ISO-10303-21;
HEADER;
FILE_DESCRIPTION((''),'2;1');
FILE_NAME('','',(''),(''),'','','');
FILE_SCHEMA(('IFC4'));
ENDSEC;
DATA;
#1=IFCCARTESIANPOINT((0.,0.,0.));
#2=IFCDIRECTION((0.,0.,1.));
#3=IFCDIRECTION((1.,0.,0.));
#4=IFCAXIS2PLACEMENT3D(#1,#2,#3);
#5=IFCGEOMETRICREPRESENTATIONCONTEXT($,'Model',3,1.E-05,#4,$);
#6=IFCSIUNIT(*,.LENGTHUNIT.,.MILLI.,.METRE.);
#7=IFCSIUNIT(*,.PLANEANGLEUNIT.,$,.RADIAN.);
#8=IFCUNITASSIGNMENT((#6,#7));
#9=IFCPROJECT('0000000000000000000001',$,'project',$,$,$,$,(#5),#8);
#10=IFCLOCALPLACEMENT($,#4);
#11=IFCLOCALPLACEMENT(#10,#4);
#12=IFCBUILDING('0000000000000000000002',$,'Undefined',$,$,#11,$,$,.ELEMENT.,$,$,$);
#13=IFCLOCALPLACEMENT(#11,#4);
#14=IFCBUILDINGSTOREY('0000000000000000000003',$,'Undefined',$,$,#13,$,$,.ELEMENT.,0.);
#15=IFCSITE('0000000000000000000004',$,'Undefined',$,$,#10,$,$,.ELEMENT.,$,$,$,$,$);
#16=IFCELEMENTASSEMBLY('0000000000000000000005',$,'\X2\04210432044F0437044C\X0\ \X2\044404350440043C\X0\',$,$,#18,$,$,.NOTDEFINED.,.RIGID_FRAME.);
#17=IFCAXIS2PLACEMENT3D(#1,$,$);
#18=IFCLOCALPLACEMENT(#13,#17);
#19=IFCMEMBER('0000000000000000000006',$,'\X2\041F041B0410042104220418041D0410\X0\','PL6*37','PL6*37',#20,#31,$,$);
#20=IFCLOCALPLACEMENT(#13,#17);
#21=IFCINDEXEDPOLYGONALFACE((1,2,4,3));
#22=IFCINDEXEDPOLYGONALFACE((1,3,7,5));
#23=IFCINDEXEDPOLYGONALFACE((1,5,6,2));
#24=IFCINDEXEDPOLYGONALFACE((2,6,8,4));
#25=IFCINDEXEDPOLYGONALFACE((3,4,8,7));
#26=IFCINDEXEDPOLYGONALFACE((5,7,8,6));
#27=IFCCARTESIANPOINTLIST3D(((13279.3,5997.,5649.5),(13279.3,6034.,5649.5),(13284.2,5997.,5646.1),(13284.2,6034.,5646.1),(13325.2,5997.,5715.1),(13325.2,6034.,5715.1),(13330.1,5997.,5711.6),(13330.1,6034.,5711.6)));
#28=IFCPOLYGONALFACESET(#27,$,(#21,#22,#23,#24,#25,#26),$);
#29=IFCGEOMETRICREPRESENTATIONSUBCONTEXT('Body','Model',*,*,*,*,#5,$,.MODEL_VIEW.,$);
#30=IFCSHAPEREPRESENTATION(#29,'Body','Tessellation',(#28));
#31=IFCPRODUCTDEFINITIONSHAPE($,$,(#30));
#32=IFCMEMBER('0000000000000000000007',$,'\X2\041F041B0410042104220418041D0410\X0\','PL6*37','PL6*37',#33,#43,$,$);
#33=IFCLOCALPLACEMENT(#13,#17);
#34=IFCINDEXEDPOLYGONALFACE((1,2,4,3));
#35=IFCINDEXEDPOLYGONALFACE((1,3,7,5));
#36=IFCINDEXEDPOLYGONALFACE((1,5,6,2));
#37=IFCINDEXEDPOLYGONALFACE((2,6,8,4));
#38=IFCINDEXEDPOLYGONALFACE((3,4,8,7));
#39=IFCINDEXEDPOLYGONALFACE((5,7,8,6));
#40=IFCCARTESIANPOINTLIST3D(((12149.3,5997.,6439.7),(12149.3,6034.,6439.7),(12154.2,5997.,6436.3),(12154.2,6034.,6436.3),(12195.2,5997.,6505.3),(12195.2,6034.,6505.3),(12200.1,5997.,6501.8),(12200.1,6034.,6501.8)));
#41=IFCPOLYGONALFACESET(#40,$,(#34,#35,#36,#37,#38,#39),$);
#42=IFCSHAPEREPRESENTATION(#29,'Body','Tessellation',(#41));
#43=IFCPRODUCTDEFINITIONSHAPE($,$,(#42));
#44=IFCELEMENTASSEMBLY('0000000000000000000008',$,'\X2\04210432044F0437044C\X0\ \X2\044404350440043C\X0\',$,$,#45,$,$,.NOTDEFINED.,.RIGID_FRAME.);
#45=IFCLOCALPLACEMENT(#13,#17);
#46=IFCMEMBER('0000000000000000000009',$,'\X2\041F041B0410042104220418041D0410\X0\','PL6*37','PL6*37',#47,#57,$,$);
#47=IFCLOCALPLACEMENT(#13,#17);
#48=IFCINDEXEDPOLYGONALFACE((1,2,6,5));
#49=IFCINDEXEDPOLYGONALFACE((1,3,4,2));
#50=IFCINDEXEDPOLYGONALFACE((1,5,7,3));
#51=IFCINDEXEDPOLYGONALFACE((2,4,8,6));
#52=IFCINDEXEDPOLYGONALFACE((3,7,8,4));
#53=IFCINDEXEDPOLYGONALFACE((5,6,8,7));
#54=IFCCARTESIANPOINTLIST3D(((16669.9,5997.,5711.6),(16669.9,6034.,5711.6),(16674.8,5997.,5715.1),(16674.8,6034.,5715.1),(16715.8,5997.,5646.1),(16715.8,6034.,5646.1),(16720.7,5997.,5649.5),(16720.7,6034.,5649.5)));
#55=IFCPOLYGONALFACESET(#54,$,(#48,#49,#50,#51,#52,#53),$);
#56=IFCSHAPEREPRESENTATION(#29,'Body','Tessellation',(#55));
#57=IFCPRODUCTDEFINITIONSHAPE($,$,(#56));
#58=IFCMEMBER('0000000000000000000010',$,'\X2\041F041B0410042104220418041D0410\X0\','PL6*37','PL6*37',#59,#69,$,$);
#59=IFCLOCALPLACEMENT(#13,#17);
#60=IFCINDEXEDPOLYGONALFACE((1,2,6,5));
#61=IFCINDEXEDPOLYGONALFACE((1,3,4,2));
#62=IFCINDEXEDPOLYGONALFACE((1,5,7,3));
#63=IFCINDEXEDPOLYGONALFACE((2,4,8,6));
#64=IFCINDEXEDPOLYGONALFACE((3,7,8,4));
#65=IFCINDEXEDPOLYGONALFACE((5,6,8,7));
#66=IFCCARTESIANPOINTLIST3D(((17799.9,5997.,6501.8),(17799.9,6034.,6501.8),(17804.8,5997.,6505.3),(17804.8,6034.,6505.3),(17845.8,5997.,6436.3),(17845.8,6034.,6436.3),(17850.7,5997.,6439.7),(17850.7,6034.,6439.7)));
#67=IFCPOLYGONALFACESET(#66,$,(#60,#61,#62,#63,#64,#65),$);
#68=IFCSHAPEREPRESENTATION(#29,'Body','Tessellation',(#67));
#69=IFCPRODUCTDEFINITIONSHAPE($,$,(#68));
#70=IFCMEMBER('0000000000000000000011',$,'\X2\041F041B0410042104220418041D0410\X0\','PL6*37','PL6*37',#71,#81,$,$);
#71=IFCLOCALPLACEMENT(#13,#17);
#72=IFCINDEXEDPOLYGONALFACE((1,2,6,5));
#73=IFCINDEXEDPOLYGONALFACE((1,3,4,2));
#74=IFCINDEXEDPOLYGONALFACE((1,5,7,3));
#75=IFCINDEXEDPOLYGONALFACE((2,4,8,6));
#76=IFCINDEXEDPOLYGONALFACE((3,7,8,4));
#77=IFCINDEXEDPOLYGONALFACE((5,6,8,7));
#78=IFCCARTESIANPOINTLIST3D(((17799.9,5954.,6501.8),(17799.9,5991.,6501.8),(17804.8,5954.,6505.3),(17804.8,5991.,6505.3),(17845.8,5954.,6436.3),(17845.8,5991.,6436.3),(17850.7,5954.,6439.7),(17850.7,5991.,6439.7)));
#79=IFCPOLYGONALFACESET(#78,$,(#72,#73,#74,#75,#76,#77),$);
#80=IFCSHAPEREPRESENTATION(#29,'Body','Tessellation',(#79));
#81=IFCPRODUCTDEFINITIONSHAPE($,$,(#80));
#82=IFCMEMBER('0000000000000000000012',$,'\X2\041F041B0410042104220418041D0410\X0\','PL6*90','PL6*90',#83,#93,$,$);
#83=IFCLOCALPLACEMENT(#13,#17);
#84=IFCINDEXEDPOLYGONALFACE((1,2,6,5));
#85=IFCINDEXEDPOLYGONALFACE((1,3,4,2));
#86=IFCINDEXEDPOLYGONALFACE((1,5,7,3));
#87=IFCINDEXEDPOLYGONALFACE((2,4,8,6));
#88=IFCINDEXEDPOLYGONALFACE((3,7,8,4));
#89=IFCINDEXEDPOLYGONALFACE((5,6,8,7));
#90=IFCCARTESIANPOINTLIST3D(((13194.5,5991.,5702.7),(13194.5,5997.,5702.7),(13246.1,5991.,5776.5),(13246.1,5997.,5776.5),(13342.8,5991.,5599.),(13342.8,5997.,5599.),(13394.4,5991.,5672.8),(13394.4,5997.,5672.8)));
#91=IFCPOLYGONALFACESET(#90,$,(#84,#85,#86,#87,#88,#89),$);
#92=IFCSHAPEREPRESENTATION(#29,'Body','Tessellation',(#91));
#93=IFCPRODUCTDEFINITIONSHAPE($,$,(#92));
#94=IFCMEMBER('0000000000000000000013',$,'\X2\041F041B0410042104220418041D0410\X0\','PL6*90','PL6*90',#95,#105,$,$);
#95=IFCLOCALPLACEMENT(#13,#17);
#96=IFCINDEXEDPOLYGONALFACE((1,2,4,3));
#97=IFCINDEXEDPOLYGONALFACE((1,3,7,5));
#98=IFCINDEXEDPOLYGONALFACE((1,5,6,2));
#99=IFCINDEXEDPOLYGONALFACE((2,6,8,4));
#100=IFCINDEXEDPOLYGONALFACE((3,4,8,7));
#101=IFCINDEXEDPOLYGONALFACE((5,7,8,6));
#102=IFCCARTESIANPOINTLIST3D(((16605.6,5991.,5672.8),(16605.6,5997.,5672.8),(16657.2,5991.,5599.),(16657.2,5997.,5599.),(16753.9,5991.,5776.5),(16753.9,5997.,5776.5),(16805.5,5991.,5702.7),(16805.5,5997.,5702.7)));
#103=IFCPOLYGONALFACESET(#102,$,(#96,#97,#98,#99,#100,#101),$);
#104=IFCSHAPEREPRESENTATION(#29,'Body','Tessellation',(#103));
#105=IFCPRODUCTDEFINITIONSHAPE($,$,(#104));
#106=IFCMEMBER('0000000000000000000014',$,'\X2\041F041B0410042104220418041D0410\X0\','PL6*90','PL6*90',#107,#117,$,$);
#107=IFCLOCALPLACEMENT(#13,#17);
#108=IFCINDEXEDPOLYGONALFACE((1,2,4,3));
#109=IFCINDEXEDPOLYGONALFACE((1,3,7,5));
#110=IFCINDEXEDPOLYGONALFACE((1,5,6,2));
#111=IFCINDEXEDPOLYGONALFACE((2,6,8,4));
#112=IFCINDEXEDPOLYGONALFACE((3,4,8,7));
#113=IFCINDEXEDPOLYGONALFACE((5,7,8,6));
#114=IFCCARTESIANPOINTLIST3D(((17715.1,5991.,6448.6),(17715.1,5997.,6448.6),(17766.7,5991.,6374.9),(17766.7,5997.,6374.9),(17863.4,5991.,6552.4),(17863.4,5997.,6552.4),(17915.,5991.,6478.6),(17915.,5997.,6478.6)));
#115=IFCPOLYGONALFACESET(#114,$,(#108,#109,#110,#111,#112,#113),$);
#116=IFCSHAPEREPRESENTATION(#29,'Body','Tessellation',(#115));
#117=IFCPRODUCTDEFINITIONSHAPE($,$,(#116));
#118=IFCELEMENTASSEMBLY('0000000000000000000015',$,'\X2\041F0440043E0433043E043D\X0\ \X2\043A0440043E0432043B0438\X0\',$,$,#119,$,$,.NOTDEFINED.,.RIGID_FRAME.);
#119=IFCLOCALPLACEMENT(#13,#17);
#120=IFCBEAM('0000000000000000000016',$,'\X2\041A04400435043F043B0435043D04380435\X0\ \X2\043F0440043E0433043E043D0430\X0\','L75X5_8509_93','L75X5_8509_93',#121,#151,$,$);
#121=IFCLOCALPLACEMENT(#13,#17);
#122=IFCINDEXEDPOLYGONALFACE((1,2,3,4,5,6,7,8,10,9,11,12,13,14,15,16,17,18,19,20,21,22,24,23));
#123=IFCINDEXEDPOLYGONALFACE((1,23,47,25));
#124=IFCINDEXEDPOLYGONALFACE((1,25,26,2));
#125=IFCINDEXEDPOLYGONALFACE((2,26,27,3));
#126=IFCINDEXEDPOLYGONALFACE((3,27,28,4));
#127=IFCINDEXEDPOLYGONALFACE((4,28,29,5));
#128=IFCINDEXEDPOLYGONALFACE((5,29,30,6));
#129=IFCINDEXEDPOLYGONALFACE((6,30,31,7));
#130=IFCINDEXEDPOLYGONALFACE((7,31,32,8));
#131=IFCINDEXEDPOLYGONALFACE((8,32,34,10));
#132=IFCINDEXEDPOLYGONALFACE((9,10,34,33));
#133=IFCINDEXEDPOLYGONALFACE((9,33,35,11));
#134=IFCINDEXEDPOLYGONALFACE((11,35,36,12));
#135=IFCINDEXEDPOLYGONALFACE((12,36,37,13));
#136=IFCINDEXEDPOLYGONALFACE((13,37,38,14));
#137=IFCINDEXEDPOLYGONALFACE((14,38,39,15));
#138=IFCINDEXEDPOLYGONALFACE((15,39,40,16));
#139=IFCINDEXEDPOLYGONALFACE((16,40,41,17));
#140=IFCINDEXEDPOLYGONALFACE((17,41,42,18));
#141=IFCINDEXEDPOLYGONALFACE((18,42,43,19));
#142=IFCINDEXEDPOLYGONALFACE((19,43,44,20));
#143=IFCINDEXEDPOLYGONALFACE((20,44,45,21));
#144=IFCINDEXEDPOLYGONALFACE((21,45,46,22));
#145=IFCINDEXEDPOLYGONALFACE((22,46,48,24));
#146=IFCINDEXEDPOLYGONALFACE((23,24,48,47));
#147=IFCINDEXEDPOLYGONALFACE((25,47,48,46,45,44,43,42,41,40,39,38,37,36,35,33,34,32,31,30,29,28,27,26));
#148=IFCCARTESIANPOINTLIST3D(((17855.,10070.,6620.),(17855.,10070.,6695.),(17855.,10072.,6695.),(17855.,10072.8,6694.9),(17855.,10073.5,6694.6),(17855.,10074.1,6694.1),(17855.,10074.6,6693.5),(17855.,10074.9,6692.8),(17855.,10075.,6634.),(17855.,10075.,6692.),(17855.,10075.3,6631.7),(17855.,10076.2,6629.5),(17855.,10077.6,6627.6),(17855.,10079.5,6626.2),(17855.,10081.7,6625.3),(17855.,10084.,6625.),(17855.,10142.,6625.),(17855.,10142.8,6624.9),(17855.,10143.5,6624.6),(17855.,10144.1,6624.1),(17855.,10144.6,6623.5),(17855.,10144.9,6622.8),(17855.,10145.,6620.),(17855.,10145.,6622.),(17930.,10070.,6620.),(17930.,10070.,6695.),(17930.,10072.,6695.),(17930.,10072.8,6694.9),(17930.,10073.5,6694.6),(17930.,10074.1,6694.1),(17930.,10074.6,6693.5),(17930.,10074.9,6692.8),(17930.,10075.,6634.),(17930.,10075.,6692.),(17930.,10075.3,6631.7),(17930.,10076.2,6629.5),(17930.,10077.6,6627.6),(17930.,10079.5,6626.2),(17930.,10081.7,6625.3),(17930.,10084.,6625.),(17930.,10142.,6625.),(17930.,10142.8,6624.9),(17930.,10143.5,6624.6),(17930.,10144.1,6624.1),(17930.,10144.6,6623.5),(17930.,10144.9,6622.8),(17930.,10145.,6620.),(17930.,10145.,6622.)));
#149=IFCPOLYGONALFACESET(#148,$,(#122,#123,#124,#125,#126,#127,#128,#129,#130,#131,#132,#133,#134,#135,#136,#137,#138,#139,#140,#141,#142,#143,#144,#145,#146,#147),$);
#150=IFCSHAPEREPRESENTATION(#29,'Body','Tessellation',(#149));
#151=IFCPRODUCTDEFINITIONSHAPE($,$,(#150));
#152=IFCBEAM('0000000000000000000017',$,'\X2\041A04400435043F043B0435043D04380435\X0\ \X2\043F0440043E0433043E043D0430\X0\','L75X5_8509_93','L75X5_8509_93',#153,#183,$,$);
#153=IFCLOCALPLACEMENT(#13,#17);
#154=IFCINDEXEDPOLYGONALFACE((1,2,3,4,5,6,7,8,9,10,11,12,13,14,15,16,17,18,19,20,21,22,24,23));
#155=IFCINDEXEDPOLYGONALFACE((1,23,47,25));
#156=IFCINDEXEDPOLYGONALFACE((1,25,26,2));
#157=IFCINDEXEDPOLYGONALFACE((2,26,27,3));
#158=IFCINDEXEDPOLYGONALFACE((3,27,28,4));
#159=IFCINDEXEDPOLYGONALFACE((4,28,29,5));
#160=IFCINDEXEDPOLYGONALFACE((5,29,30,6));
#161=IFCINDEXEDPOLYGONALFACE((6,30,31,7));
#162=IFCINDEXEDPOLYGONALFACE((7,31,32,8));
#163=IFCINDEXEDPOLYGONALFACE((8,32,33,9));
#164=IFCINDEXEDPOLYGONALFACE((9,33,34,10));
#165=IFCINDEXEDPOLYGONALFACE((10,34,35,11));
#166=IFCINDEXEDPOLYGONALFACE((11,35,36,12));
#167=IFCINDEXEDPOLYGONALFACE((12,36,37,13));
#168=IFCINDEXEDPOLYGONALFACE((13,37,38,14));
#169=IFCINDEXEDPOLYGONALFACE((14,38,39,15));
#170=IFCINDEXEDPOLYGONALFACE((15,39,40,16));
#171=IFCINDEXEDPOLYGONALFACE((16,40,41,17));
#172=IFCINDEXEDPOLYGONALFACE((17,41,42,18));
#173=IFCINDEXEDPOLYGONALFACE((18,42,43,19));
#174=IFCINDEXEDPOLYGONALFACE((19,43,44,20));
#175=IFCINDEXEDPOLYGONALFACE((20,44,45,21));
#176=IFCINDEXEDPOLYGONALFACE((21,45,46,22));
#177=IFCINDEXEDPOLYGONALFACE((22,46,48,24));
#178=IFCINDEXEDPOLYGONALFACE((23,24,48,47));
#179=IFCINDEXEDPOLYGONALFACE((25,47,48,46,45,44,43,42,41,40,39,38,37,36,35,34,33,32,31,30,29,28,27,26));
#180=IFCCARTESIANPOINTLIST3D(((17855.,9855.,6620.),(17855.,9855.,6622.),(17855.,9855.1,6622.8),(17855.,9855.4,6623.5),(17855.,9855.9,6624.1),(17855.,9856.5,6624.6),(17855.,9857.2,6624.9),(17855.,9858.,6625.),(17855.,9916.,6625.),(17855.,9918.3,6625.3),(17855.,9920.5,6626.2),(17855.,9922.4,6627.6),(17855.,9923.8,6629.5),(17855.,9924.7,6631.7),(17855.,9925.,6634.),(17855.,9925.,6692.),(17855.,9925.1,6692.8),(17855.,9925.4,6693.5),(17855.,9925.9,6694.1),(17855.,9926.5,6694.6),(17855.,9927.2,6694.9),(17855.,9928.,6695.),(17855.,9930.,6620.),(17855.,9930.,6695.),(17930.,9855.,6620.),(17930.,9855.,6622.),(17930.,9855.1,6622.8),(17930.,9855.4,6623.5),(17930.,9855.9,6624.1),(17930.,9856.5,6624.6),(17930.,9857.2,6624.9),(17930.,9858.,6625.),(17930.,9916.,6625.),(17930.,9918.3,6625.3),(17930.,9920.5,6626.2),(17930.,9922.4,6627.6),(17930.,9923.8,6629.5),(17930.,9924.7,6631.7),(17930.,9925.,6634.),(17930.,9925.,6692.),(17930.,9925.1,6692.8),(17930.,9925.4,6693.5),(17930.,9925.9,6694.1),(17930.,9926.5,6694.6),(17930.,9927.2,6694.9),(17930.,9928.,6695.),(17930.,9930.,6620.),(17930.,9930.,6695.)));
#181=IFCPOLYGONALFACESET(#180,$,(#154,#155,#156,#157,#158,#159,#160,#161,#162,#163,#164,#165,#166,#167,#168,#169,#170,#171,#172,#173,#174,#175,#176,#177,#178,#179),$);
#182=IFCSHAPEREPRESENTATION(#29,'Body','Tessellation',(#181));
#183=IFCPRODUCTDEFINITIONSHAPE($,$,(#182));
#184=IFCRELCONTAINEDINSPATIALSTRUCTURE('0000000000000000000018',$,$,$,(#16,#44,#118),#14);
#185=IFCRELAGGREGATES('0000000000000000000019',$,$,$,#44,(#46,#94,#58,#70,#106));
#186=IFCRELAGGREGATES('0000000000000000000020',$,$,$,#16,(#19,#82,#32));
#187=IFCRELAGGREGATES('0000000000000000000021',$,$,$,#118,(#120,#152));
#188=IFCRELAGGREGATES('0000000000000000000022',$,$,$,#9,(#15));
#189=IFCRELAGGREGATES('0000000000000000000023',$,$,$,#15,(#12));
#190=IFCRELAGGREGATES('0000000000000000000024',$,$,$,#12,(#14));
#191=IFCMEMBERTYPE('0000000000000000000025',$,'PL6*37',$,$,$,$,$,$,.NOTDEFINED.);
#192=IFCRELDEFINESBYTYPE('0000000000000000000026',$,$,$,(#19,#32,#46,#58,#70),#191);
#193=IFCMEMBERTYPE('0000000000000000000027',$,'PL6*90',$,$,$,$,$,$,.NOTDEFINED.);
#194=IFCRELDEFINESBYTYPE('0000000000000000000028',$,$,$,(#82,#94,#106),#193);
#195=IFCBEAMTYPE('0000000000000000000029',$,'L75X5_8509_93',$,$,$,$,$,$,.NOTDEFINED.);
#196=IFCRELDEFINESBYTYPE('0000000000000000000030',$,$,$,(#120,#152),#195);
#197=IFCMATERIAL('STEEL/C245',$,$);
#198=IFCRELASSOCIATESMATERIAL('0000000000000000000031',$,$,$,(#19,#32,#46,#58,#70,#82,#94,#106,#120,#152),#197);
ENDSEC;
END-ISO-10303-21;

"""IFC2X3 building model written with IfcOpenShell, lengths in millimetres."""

from ifc_helpers import new_model, si_unit, frame, origin_with_axes, origin_2d_with_axis, place, context, subcontext, project, spatial, rectangle, l_section, extrude, material, type_object, element, aggregate, save


model = new_model("IFC2X3")

# Units and contexts
model_context = context("Model", 3, precision=1e-05, world=origin_with_axes())
body_context = subcontext(model_context, "Body", "Model", "MODEL_VIEW")
ifc_project = project(units=[si_unit("LENGTHUNIT", "METRE", prefix="MILLI"), si_unit("PLANEANGLEUNIT", "RADIAN")], contexts=[model_context])

# Site, building, storey
site_placement = place(None, origin_with_axes())
site = spatial("IfcSite", under=ifc_project, at=site_placement, Name="Undefined", CompositionType="ELEMENT")
building_placement = place(site_placement, origin_with_axes())
building = spatial("IfcBuilding", under=site, at=building_placement, Name="Undefined", CompositionType="ELEMENT")
storey_placement = place(building_placement, origin_with_axes())
storey = spatial("IfcBuildingStorey", under=building, at=storey_placement, Name="Undefined", CompositionType="ELEMENT", Elevation=0.0)

# Element assemblies, members
assembly_1_placement = place(storey_placement, origin_with_axes())
assembly_1 = element("IfcElementAssembly", 1, at=assembly_1_placement, inside=storey, Name="Связь ферм", AssemblyPlace="NOTDEFINED", PredefinedType="RIGID_FRAME")
ifc_material_1 = material(Name="STEEL/C245")
member_type_1 = type_object("IfcMemberType", Name="PL6*37", PredefinedType="NOTDEFINED")
member_1_placement = place(assembly_1_placement, frame((13281.8, 6015.5, 5647.8), z_axis=(0.0, -1.0, 0.0), x_axis=(0.573078, 0.0, 0.819501)))
member_1 = element("IfcMember", 2, at=member_1_placement, type_object=member_type_1, material=ifc_material_1, Name="ПЛАСТИНА", Description="PL6*37", ObjectType="PL6*37", context=body_context, shape_type="SweptSolid", body=[
    extrude(rectangle(XDim=6.0, YDim=37.0, at=origin_2d_with_axis()), frame((80.0, 0.0, 0.0), z_axis=(-1.0, 0.0, 0.0), x_axis=(0.0, -1.0, 0.0)), (0.0, 0.0, 1.0), 80.0),
])
member_2_placement = place(assembly_1_placement, frame((12151.8, 6015.5, 6438.0), z_axis=(0.0, -1.0, 0.0), x_axis=(0.573078, 0.0, 0.819501)))
member_2 = element("IfcMember", 3, at=member_2_placement, type_object=member_type_1, material=ifc_material_1, Name="ПЛАСТИНА", Description="PL6*37", ObjectType="PL6*37", context=body_context, shape_type="SweptSolid", body=[
    extrude(rectangle(XDim=6.0, YDim=37.0, at=origin_2d_with_axis()), frame((80.0, 0.0, 0.0), z_axis=(-1.0, 0.0, 0.0), x_axis=(0.0, -1.0, 0.0)), (0.0, 0.0, 1.0), 80.0),
])
assembly_2_placement = place(storey_placement, origin_with_axes())
assembly_2 = element("IfcElementAssembly", 4, at=assembly_2_placement, inside=storey, Name="Связь ферм", AssemblyPlace="NOTDEFINED", PredefinedType="RIGID_FRAME")
member_3_placement = place(assembly_2_placement, frame((16718.2, 6015.5, 5647.8), z_axis=(0.0, -1.0, 0.0), x_axis=(-0.573078, 0.0, 0.819501)))
member_3 = element("IfcMember", 5, at=member_3_placement, type_object=member_type_1, material=ifc_material_1, Name="ПЛАСТИНА", Description="PL6*37", ObjectType="PL6*37", context=body_context, shape_type="SweptSolid", body=[
    extrude(rectangle(XDim=6.0, YDim=37.0, at=origin_2d_with_axis()), frame((80.0, 0.0, 0.0), z_axis=(-1.0, 0.0, 0.0), x_axis=(0.0, -1.0, 0.0)), (0.0, 0.0, 1.0), 80.0),
])
member_4_placement = place(assembly_2_placement, frame((17802.4, 6015.5, 6503.6), z_axis=(0.0, -1.0, 0.0), x_axis=(0.573078, 0.0, -0.819501)))
member_4 = element("IfcMember", 6, at=member_4_placement, type_object=member_type_1, material=ifc_material_1, Name="ПЛАСТИНА", Description="PL6*37", ObjectType="PL6*37", context=body_context, shape_type="SweptSolid", body=[
    extrude(rectangle(XDim=6.0, YDim=37.0, at=origin_2d_with_axis()), frame((80.0, 0.0, 0.0), z_axis=(-1.0, 0.0, 0.0), x_axis=(0.0, -1.0, 0.0)), (0.0, 0.0, 1.0), 80.0),
])
member_5_placement = place(assembly_2_placement, frame((17802.4, 5972.5, 6503.6), z_axis=(0.0, 1.0, 0.0), x_axis=(0.573078, 0.0, -0.819501)))
member_5 = element("IfcMember", 7, at=member_5_placement, type_object=member_type_1, material=ifc_material_1, Name="ПЛАСТИНА", Description="PL6*37", ObjectType="PL6*37", context=body_context, shape_type="SweptSolid", body=[
    extrude(rectangle(XDim=6.0, YDim=37.0, at=origin_2d_with_axis()), frame((80.0, 0.0, 0.0), z_axis=(-1.0, 0.0, 0.0), x_axis=(0.0, -1.0, 0.0)), (0.0, 0.0, 1.0), 80.0),
])

# Members
member_type_2 = type_object("IfcMemberType", Name="PL6*90", PredefinedType="NOTDEFINED")
member_6_placement = place(assembly_1_placement, frame((13368.6, 5994.0, 5635.9), z_axis=(-0.573078, 0.0, -0.819501), x_axis=(-0.819501, 0.0, 0.573078)))
member_6 = element("IfcMember", 8, at=member_6_placement, type_object=member_type_2, material=ifc_material_1, Name="ПЛАСТИНА", Description="PL6*90", ObjectType="PL6*90", context=body_context, shape_type="SweptSolid", body=[
    extrude(rectangle(XDim=6.0, YDim=90.0, at=origin_2d_with_axis()), frame((181.0, 0.0, 0.0), z_axis=(-1.0, 0.0, 0.0), x_axis=(0.0, -1.0, 0.0)), (0.0, 0.0, 1.0), 181.0),
])
member_7_placement = place(assembly_2_placement, frame((16631.4, 5994.0, 5635.9), z_axis=(0.573078, 0.0, -0.819501), x_axis=(0.819501, 0.0, 0.573078)))
member_7 = element("IfcMember", 9, at=member_7_placement, type_object=member_type_2, material=ifc_material_1, Name="ПЛАСТИНА", Description="PL6*90", ObjectType="PL6*90", context=body_context, shape_type="SweptSolid", body=[
    extrude(rectangle(XDim=6.0, YDim=90.0, at=origin_2d_with_axis()), frame((181.0, 0.0, 0.0), z_axis=(-1.0, 0.0, 0.0), x_axis=(0.0, -1.0, 0.0)), (0.0, 0.0, 1.0), 181.0),
])
member_8_placement = place(assembly_2_placement, frame((17889.2, 5994.0, 6515.5), z_axis=(-0.573078, 0.0, 0.819501), x_axis=(-0.819501, 0.0, -0.573078)))
member_8 = element("IfcMember", 10, at=member_8_placement, type_object=member_type_2, material=ifc_material_1, Name="ПЛАСТИНА", Description="PL6*90", ObjectType="PL6*90", context=body_context, shape_type="SweptSolid", body=[
    extrude(rectangle(XDim=6.0, YDim=90.0, at=origin_2d_with_axis()), frame((181.0, 0.0, 0.0), z_axis=(-1.0, 0.0, 0.0), x_axis=(0.0, -1.0, 0.0)), (0.0, 0.0, 1.0), 181.0),
])

# Element assembly, beams
assembly_3_placement = place(storey_placement, origin_with_axes())
assembly_3 = element("IfcElementAssembly", 11, at=assembly_3_placement, inside=storey, Name="Прогон кровли", AssemblyPlace="NOTDEFINED", PredefinedType="RIGID_FRAME")
beam_type = type_object("IfcBeamType", Name="L75X5_8509_93", PredefinedType="NOTDEFINED")
beam_1_placement = place(assembly_3_placement, frame((17855.0, 10107.5, 6657.5), z_axis=(0.0, 1.0, 0.0), x_axis=(1.0, 0.0, 0.0)))
beam_1 = element("IfcBeam", 12, at=beam_1_placement, type_object=beam_type, material=ifc_material_1, Name="Крепление прогона", Description="L75X5_8509_93", ObjectType="L75X5_8509_93", context=body_context, shape_type="SweptSolid", body=[
    extrude(l_section(Depth=75.0, Width=75.0, Thickness=5.0, FilletRadius=9.0, EdgeRadius=3.0, at=origin_2d_with_axis()), frame((75.0, 0.0, 0.0), z_axis=(-1.0, 0.0, 0.0), x_axis=(0.0, -1.0, 0.0)), (0.0, 0.0, 1.0), 75.0),
])
beam_2_placement = place(assembly_3_placement, frame((17930.0, 9892.5, 6657.5), z_axis=(0.0, -1.0, 0.0), x_axis=(-1.0, 0.0, 0.0)))
beam_2 = element("IfcBeam", 13, at=beam_2_placement, type_object=beam_type, material=ifc_material_1, Name="Крепление прогона", Description="L75X5_8509_93", ObjectType="L75X5_8509_93", context=body_context, shape_type="SweptSolid", body=[
    extrude(l_section(Depth=75.0, Width=75.0, Thickness=5.0, FilletRadius=9.0, EdgeRadius=3.0, at=origin_2d_with_axis()), frame((75.0, 0.0, 0.0), z_axis=(-1.0, 0.0, 0.0), x_axis=(0.0, -1.0, 0.0)), (0.0, 0.0, 1.0), 75.0),
])

aggregate(assembly_2, [member_3, member_7, member_4, member_5, member_8])
aggregate(assembly_1, [member_1, member_6, member_2])
aggregate(assembly_3, [beam_1, beam_2])

save(model, "model.ifc")
